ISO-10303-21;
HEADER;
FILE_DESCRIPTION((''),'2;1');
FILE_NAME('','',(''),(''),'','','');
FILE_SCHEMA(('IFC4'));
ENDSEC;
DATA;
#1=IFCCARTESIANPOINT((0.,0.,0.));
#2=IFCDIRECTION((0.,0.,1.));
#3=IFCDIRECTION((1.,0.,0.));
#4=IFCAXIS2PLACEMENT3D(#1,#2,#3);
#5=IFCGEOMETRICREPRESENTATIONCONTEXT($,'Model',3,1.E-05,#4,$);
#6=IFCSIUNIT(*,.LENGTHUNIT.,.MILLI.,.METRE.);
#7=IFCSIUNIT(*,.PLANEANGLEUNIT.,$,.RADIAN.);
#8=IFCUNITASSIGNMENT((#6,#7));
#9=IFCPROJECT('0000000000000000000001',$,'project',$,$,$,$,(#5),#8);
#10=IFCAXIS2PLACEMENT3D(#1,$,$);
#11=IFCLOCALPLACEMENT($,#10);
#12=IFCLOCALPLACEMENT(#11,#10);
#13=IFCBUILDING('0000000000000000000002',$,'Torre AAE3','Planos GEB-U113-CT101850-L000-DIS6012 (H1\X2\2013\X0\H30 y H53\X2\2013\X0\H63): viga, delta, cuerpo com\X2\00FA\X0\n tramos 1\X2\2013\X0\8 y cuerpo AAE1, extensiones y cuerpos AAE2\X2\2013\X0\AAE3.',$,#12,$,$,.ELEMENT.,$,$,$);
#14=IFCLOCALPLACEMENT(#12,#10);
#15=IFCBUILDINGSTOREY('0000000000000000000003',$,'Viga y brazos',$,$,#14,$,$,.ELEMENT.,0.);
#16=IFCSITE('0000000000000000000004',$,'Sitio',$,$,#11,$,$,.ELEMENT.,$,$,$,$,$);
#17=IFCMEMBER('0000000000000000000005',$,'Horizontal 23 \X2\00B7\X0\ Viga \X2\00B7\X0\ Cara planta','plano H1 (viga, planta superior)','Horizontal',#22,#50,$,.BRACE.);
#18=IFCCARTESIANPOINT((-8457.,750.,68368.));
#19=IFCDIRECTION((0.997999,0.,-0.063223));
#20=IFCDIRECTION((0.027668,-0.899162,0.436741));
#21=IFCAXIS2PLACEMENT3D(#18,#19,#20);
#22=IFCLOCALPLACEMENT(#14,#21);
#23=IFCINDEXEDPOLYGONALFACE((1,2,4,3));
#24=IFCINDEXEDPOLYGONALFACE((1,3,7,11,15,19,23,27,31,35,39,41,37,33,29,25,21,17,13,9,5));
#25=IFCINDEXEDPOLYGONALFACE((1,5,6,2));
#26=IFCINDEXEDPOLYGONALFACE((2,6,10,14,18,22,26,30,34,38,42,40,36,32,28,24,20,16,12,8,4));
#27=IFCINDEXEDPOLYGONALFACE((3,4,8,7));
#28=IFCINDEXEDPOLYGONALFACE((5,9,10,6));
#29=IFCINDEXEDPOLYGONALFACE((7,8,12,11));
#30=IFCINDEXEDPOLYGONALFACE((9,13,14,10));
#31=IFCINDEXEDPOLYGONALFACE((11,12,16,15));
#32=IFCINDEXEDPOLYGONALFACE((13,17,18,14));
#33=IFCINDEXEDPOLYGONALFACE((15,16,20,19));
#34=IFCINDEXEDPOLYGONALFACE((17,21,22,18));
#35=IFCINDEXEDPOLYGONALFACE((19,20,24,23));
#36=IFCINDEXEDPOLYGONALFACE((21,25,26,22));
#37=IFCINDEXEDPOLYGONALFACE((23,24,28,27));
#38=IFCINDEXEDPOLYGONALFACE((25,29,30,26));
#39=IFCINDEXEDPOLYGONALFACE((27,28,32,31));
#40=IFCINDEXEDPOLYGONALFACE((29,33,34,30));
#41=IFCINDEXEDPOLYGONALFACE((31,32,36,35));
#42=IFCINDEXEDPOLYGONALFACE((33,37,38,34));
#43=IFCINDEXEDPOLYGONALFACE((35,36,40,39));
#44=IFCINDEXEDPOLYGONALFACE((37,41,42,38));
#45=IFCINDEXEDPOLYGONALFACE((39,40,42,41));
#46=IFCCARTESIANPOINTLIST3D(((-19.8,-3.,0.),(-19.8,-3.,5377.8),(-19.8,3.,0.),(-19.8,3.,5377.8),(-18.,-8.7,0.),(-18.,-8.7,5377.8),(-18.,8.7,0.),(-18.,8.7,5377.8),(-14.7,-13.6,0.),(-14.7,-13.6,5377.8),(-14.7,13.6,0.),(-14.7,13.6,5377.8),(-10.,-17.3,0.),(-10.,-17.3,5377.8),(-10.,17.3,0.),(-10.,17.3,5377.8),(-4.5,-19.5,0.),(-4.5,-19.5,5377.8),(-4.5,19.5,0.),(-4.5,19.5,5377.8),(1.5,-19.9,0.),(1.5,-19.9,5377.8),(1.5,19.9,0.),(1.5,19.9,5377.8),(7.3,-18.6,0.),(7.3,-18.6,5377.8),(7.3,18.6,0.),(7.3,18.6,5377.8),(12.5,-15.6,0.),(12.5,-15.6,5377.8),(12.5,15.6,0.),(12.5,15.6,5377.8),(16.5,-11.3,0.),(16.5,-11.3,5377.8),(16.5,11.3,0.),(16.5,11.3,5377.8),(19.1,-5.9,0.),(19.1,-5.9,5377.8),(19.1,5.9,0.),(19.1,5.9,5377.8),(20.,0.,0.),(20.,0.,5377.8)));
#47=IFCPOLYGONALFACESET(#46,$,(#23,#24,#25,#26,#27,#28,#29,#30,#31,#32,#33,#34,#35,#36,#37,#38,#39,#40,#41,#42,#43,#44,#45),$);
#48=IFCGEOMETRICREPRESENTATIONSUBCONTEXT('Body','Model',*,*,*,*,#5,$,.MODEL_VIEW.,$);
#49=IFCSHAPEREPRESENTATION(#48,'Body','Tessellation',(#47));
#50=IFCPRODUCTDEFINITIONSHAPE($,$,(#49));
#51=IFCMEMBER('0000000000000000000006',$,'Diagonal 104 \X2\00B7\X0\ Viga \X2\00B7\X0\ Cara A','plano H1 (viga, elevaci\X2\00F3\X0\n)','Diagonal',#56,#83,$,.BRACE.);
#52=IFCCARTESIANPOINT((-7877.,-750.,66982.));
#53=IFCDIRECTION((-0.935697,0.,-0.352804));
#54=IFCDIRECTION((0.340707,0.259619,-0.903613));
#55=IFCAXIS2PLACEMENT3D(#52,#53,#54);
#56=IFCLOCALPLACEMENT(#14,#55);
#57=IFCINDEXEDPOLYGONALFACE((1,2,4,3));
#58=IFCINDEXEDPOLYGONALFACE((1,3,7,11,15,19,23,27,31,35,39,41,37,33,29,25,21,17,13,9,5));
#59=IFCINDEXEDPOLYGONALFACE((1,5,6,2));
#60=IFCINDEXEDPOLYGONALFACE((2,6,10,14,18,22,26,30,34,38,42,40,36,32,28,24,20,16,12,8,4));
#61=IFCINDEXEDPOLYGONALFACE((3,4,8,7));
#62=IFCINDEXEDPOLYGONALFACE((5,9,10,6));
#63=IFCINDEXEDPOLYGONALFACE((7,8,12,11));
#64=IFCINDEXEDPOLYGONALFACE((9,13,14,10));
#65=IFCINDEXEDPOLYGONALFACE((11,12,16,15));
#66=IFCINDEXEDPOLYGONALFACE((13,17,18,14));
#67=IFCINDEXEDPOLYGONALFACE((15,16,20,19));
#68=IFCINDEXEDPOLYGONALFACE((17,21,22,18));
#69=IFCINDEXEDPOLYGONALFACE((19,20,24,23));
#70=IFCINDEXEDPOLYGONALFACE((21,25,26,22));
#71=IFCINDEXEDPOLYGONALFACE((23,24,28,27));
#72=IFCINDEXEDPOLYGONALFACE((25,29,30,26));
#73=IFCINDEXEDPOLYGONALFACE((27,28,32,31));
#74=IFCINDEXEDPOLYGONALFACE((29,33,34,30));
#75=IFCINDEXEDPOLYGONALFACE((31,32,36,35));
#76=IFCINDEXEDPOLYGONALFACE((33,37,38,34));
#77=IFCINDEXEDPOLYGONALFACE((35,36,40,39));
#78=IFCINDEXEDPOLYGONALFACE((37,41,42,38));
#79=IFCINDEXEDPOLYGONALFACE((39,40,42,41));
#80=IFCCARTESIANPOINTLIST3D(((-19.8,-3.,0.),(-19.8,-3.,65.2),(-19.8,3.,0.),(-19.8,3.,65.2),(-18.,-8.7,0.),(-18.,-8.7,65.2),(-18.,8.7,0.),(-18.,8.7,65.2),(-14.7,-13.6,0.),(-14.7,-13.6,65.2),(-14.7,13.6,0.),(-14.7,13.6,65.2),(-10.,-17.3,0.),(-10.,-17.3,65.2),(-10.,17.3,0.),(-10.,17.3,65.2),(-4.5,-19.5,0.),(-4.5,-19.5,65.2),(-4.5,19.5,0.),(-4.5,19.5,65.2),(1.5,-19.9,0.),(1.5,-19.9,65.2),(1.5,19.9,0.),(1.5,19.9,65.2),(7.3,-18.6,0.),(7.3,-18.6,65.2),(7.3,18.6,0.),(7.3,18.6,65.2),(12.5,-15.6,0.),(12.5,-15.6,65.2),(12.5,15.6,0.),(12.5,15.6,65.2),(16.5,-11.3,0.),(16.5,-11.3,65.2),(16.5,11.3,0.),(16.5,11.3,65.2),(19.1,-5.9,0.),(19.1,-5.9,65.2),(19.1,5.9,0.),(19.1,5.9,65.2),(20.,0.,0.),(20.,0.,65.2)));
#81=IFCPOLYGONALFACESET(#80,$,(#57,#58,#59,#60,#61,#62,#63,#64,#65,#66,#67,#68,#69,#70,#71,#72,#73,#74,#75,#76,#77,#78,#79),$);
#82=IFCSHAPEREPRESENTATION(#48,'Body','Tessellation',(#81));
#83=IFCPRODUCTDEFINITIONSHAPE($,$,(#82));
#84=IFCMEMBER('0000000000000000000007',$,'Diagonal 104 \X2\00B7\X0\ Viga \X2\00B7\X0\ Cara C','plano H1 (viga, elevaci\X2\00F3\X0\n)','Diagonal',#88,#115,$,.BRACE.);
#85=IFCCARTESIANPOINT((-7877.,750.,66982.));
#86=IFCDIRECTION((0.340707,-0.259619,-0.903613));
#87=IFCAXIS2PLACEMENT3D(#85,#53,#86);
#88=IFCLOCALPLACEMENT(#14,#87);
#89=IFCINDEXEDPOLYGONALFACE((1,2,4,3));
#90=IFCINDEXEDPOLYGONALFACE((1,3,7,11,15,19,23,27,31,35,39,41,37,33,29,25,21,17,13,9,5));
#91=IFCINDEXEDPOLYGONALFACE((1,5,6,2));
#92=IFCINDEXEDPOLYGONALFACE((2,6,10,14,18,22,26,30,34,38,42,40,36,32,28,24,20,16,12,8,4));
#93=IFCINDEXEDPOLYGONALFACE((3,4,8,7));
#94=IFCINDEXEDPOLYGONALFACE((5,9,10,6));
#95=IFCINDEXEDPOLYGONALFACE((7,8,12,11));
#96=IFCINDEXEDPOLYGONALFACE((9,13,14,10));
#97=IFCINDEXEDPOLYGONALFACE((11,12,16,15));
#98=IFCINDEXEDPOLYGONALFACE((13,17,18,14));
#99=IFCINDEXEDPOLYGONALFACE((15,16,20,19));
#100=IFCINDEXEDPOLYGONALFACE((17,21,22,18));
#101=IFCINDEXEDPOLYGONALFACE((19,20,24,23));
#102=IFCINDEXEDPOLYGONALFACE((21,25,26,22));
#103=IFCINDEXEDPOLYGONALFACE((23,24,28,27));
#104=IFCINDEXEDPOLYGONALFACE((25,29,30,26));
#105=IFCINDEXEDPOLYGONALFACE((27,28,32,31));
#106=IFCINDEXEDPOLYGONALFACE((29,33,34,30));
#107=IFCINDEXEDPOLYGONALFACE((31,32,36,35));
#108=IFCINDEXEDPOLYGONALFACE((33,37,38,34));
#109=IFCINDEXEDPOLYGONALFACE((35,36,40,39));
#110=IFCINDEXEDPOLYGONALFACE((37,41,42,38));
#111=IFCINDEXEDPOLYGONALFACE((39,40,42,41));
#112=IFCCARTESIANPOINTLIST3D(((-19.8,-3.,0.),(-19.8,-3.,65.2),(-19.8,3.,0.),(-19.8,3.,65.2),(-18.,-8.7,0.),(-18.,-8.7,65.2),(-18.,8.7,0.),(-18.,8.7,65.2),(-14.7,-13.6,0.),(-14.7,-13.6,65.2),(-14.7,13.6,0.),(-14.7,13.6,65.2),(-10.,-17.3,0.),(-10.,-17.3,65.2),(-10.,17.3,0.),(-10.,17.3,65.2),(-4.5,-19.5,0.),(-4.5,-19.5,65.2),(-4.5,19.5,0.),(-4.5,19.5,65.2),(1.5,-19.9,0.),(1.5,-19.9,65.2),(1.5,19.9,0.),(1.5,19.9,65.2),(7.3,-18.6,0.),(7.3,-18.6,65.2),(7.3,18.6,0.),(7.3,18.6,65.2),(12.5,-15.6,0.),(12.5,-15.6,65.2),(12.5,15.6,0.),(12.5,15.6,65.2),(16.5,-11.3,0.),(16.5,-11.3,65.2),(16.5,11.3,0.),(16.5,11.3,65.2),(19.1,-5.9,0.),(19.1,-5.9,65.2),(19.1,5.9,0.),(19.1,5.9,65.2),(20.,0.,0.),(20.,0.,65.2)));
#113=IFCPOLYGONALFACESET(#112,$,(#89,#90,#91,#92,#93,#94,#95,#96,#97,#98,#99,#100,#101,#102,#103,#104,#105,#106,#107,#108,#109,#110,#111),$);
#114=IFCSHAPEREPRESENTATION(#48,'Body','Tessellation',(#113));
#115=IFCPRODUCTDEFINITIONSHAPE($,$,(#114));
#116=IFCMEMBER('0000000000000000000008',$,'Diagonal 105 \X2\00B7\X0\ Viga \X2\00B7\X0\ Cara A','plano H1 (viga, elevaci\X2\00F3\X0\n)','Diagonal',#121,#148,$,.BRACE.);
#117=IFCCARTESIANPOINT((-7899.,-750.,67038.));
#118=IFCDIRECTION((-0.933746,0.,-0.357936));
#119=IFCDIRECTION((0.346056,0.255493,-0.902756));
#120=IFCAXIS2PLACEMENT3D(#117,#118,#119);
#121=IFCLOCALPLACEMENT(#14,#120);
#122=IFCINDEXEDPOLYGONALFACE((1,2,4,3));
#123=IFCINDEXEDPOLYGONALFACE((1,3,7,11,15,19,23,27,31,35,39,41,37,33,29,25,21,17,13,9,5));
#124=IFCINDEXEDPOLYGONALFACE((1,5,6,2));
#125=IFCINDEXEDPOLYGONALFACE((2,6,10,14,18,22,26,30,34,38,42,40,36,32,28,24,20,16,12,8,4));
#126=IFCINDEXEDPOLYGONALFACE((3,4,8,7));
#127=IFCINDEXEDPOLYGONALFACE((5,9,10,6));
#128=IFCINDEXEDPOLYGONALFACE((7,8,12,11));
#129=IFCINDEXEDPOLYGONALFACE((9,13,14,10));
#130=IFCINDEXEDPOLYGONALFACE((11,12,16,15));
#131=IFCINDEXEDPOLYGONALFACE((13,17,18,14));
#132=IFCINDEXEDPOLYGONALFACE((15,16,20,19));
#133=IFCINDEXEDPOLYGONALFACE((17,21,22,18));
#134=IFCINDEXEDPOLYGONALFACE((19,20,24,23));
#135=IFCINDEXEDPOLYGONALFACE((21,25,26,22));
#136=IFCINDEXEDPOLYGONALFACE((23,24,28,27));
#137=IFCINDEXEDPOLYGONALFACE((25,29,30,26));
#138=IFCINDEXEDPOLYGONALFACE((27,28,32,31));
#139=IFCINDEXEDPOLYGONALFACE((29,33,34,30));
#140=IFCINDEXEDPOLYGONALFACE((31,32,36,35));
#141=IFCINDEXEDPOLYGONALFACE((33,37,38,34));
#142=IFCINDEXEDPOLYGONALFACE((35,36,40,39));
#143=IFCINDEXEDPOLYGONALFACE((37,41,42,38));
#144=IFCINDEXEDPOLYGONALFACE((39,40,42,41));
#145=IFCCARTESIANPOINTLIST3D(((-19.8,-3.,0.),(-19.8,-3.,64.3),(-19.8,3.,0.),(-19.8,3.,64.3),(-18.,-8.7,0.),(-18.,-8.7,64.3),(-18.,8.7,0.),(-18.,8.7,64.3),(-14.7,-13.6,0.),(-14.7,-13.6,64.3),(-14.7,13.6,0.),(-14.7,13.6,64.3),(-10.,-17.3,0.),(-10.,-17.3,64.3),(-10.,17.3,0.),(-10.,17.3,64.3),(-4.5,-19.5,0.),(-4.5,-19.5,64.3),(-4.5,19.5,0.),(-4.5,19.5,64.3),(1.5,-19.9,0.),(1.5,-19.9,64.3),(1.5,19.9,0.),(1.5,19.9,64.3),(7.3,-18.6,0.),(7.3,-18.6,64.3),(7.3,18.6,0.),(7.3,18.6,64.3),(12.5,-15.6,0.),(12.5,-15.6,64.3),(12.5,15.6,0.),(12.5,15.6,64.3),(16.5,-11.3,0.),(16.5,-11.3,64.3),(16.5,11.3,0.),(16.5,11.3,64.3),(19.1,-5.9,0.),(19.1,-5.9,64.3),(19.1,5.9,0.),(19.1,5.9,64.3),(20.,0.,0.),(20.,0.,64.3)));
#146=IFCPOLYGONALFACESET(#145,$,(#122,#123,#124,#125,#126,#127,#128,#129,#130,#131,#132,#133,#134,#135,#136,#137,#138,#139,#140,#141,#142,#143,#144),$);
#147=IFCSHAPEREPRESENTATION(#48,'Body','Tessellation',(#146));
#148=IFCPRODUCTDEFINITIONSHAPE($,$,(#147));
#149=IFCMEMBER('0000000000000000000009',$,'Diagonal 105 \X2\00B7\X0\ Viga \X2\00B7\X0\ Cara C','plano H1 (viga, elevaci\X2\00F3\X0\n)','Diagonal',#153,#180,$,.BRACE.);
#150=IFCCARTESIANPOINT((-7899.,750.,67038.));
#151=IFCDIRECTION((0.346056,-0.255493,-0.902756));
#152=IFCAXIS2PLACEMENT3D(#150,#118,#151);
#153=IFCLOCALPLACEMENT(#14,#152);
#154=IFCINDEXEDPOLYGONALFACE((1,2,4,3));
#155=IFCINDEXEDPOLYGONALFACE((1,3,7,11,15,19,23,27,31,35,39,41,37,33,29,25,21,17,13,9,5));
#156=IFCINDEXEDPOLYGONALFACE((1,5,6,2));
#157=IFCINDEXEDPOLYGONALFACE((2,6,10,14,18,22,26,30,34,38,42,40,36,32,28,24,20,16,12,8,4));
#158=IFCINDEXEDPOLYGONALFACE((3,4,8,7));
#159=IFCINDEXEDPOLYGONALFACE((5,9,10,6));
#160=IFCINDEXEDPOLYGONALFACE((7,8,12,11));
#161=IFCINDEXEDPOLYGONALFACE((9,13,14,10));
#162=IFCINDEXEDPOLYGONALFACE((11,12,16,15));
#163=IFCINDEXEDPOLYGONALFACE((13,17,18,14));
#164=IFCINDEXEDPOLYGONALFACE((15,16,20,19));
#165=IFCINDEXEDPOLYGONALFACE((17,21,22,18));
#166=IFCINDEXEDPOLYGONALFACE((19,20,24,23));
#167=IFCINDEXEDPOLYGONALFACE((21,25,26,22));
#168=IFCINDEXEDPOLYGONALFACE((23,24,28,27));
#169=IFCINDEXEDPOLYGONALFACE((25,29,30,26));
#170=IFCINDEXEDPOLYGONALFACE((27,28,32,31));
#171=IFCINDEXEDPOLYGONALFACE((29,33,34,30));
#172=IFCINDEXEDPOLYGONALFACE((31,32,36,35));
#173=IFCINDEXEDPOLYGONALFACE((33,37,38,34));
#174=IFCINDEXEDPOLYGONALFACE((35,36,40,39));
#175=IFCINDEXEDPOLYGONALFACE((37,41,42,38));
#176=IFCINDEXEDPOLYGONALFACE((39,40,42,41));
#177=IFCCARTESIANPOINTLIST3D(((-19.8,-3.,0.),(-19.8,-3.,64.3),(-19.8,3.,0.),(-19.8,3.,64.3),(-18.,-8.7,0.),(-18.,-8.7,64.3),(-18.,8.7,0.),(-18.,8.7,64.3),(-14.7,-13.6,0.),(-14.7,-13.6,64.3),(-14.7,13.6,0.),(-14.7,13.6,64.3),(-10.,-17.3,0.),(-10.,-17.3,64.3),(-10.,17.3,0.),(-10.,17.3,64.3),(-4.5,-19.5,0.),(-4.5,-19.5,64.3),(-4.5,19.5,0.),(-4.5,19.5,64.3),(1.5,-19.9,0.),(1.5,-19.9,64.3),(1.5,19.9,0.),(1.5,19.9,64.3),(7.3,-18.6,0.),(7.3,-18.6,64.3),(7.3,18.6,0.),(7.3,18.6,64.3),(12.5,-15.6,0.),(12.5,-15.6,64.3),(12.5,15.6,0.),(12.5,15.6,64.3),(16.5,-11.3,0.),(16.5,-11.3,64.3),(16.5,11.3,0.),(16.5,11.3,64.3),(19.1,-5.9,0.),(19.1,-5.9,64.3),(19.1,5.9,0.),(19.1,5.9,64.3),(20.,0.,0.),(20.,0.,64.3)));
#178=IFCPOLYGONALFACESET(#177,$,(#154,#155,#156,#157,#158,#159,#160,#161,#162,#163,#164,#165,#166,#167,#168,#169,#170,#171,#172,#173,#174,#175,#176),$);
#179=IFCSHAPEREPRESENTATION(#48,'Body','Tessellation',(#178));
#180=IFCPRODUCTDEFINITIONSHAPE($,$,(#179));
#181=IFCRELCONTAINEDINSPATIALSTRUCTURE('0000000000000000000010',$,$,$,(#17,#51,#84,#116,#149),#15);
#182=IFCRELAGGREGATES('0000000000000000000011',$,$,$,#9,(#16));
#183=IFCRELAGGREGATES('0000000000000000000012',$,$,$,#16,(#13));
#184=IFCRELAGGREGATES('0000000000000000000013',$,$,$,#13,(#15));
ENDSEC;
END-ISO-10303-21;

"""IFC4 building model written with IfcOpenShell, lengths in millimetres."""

from ifc_helpers import new_model, si_unit, frame, origin, origin_with_axes, place, context, subcontext, project, spatial, circle, extrude, element, save


model = new_model("IFC4")

# Units and contexts
model_context = context("Model", 3, precision=1e-05, world=origin_with_axes())
body_context = subcontext(model_context, "Body", "Model", "MODEL_VIEW")
ifc_project = project(units=[si_unit("LENGTHUNIT", "METRE", prefix="MILLI"), si_unit("PLANEANGLEUNIT", "RADIAN")], contexts=[model_context])

# Site, building, storey
site_placement = place(None, origin())
site = spatial("IfcSite", under=ifc_project, at=site_placement, Name="Sitio", CompositionType="ELEMENT")
building_placement = place(site_placement, origin())
building = spatial("IfcBuilding", under=site, at=building_placement, Name="Torre AAE3", Description="Planos GEB-U113-CT101850-L000-DIS6012 (H1–H30 y H53–H63): viga, delta, cuerpo común tramos 1–8 y cuerpo AAE1, extensiones y cuerpos AAE2–AAE3.", CompositionType="ELEMENT")
storey_placement = place(building_placement, origin())
storey = spatial("IfcBuildingStorey", under=building, at=storey_placement, Name="Viga y brazos", CompositionType="ELEMENT", Elevation=0.0)

# Members
member_1_placement = place(storey_placement, frame((-8457.0, 750.0, 68368.0), z_axis=(0.997999, 0.0, -0.063223), x_axis=(0.027668, -0.899162, 0.436741)))
element("IfcMember", 1, at=member_1_placement, inside=storey, Name="Horizontal 23 · Viga · Cara planta", Description="plano H1 (viga, planta superior)", ObjectType="Horizontal", PredefinedType="BRACE", context=body_context, shape_type="SweptSolid", body=[
    extrude(circle(Radius=20.0), None, (0.0, 0.0, 1.0), 5377.8),
])
for number, where, z_axis, x_axis, name in (
    (2, (-7877.0, -750.0, 66982.0), (-0.935697, 0.0, -0.352804), (0.340707, 0.259619, -0.903613), "Diagonal 104 · Viga · Cara A"),
    (3, (-7877.0, 750.0, 66982.0), (-0.935697, 0.0, -0.352804), (0.340707, -0.259619, -0.903613), "Diagonal 104 · Viga · Cara C"),
):
    element("IfcMember", number, at=place(storey_placement, frame(where, z_axis=z_axis, x_axis=x_axis)), inside=storey, Name=name, Description="plano H1 (viga, elevación)", ObjectType="Diagonal", PredefinedType="BRACE", context=body_context, shape_type="SweptSolid", body=[
        extrude(circle(Radius=20.0), None, (0.0, 0.0, 1.0), 65.2),
    ])
for number, where, z_axis, x_axis, name in (
    (4, (-7899.0, -750.0, 67038.0), (-0.933746, 0.0, -0.357936), (0.346056, 0.255493, -0.902756), "Diagonal 105 · Viga · Cara A"),
    (5, (-7899.0, 750.0, 67038.0), (-0.933746, 0.0, -0.357936), (0.346056, -0.255493, -0.902756), "Diagonal 105 · Viga · Cara C"),
):
    element("IfcMember", number, at=place(storey_placement, frame(where, z_axis=z_axis, x_axis=x_axis)), inside=storey, Name=name, Description="plano H1 (viga, elevación)", ObjectType="Diagonal", PredefinedType="BRACE", context=body_context, shape_type="SweptSolid", body=[
        extrude(circle(Radius=20.0), None, (0.0, 0.0, 1.0), 64.3),
    ])

save(model, "model.ifc")
